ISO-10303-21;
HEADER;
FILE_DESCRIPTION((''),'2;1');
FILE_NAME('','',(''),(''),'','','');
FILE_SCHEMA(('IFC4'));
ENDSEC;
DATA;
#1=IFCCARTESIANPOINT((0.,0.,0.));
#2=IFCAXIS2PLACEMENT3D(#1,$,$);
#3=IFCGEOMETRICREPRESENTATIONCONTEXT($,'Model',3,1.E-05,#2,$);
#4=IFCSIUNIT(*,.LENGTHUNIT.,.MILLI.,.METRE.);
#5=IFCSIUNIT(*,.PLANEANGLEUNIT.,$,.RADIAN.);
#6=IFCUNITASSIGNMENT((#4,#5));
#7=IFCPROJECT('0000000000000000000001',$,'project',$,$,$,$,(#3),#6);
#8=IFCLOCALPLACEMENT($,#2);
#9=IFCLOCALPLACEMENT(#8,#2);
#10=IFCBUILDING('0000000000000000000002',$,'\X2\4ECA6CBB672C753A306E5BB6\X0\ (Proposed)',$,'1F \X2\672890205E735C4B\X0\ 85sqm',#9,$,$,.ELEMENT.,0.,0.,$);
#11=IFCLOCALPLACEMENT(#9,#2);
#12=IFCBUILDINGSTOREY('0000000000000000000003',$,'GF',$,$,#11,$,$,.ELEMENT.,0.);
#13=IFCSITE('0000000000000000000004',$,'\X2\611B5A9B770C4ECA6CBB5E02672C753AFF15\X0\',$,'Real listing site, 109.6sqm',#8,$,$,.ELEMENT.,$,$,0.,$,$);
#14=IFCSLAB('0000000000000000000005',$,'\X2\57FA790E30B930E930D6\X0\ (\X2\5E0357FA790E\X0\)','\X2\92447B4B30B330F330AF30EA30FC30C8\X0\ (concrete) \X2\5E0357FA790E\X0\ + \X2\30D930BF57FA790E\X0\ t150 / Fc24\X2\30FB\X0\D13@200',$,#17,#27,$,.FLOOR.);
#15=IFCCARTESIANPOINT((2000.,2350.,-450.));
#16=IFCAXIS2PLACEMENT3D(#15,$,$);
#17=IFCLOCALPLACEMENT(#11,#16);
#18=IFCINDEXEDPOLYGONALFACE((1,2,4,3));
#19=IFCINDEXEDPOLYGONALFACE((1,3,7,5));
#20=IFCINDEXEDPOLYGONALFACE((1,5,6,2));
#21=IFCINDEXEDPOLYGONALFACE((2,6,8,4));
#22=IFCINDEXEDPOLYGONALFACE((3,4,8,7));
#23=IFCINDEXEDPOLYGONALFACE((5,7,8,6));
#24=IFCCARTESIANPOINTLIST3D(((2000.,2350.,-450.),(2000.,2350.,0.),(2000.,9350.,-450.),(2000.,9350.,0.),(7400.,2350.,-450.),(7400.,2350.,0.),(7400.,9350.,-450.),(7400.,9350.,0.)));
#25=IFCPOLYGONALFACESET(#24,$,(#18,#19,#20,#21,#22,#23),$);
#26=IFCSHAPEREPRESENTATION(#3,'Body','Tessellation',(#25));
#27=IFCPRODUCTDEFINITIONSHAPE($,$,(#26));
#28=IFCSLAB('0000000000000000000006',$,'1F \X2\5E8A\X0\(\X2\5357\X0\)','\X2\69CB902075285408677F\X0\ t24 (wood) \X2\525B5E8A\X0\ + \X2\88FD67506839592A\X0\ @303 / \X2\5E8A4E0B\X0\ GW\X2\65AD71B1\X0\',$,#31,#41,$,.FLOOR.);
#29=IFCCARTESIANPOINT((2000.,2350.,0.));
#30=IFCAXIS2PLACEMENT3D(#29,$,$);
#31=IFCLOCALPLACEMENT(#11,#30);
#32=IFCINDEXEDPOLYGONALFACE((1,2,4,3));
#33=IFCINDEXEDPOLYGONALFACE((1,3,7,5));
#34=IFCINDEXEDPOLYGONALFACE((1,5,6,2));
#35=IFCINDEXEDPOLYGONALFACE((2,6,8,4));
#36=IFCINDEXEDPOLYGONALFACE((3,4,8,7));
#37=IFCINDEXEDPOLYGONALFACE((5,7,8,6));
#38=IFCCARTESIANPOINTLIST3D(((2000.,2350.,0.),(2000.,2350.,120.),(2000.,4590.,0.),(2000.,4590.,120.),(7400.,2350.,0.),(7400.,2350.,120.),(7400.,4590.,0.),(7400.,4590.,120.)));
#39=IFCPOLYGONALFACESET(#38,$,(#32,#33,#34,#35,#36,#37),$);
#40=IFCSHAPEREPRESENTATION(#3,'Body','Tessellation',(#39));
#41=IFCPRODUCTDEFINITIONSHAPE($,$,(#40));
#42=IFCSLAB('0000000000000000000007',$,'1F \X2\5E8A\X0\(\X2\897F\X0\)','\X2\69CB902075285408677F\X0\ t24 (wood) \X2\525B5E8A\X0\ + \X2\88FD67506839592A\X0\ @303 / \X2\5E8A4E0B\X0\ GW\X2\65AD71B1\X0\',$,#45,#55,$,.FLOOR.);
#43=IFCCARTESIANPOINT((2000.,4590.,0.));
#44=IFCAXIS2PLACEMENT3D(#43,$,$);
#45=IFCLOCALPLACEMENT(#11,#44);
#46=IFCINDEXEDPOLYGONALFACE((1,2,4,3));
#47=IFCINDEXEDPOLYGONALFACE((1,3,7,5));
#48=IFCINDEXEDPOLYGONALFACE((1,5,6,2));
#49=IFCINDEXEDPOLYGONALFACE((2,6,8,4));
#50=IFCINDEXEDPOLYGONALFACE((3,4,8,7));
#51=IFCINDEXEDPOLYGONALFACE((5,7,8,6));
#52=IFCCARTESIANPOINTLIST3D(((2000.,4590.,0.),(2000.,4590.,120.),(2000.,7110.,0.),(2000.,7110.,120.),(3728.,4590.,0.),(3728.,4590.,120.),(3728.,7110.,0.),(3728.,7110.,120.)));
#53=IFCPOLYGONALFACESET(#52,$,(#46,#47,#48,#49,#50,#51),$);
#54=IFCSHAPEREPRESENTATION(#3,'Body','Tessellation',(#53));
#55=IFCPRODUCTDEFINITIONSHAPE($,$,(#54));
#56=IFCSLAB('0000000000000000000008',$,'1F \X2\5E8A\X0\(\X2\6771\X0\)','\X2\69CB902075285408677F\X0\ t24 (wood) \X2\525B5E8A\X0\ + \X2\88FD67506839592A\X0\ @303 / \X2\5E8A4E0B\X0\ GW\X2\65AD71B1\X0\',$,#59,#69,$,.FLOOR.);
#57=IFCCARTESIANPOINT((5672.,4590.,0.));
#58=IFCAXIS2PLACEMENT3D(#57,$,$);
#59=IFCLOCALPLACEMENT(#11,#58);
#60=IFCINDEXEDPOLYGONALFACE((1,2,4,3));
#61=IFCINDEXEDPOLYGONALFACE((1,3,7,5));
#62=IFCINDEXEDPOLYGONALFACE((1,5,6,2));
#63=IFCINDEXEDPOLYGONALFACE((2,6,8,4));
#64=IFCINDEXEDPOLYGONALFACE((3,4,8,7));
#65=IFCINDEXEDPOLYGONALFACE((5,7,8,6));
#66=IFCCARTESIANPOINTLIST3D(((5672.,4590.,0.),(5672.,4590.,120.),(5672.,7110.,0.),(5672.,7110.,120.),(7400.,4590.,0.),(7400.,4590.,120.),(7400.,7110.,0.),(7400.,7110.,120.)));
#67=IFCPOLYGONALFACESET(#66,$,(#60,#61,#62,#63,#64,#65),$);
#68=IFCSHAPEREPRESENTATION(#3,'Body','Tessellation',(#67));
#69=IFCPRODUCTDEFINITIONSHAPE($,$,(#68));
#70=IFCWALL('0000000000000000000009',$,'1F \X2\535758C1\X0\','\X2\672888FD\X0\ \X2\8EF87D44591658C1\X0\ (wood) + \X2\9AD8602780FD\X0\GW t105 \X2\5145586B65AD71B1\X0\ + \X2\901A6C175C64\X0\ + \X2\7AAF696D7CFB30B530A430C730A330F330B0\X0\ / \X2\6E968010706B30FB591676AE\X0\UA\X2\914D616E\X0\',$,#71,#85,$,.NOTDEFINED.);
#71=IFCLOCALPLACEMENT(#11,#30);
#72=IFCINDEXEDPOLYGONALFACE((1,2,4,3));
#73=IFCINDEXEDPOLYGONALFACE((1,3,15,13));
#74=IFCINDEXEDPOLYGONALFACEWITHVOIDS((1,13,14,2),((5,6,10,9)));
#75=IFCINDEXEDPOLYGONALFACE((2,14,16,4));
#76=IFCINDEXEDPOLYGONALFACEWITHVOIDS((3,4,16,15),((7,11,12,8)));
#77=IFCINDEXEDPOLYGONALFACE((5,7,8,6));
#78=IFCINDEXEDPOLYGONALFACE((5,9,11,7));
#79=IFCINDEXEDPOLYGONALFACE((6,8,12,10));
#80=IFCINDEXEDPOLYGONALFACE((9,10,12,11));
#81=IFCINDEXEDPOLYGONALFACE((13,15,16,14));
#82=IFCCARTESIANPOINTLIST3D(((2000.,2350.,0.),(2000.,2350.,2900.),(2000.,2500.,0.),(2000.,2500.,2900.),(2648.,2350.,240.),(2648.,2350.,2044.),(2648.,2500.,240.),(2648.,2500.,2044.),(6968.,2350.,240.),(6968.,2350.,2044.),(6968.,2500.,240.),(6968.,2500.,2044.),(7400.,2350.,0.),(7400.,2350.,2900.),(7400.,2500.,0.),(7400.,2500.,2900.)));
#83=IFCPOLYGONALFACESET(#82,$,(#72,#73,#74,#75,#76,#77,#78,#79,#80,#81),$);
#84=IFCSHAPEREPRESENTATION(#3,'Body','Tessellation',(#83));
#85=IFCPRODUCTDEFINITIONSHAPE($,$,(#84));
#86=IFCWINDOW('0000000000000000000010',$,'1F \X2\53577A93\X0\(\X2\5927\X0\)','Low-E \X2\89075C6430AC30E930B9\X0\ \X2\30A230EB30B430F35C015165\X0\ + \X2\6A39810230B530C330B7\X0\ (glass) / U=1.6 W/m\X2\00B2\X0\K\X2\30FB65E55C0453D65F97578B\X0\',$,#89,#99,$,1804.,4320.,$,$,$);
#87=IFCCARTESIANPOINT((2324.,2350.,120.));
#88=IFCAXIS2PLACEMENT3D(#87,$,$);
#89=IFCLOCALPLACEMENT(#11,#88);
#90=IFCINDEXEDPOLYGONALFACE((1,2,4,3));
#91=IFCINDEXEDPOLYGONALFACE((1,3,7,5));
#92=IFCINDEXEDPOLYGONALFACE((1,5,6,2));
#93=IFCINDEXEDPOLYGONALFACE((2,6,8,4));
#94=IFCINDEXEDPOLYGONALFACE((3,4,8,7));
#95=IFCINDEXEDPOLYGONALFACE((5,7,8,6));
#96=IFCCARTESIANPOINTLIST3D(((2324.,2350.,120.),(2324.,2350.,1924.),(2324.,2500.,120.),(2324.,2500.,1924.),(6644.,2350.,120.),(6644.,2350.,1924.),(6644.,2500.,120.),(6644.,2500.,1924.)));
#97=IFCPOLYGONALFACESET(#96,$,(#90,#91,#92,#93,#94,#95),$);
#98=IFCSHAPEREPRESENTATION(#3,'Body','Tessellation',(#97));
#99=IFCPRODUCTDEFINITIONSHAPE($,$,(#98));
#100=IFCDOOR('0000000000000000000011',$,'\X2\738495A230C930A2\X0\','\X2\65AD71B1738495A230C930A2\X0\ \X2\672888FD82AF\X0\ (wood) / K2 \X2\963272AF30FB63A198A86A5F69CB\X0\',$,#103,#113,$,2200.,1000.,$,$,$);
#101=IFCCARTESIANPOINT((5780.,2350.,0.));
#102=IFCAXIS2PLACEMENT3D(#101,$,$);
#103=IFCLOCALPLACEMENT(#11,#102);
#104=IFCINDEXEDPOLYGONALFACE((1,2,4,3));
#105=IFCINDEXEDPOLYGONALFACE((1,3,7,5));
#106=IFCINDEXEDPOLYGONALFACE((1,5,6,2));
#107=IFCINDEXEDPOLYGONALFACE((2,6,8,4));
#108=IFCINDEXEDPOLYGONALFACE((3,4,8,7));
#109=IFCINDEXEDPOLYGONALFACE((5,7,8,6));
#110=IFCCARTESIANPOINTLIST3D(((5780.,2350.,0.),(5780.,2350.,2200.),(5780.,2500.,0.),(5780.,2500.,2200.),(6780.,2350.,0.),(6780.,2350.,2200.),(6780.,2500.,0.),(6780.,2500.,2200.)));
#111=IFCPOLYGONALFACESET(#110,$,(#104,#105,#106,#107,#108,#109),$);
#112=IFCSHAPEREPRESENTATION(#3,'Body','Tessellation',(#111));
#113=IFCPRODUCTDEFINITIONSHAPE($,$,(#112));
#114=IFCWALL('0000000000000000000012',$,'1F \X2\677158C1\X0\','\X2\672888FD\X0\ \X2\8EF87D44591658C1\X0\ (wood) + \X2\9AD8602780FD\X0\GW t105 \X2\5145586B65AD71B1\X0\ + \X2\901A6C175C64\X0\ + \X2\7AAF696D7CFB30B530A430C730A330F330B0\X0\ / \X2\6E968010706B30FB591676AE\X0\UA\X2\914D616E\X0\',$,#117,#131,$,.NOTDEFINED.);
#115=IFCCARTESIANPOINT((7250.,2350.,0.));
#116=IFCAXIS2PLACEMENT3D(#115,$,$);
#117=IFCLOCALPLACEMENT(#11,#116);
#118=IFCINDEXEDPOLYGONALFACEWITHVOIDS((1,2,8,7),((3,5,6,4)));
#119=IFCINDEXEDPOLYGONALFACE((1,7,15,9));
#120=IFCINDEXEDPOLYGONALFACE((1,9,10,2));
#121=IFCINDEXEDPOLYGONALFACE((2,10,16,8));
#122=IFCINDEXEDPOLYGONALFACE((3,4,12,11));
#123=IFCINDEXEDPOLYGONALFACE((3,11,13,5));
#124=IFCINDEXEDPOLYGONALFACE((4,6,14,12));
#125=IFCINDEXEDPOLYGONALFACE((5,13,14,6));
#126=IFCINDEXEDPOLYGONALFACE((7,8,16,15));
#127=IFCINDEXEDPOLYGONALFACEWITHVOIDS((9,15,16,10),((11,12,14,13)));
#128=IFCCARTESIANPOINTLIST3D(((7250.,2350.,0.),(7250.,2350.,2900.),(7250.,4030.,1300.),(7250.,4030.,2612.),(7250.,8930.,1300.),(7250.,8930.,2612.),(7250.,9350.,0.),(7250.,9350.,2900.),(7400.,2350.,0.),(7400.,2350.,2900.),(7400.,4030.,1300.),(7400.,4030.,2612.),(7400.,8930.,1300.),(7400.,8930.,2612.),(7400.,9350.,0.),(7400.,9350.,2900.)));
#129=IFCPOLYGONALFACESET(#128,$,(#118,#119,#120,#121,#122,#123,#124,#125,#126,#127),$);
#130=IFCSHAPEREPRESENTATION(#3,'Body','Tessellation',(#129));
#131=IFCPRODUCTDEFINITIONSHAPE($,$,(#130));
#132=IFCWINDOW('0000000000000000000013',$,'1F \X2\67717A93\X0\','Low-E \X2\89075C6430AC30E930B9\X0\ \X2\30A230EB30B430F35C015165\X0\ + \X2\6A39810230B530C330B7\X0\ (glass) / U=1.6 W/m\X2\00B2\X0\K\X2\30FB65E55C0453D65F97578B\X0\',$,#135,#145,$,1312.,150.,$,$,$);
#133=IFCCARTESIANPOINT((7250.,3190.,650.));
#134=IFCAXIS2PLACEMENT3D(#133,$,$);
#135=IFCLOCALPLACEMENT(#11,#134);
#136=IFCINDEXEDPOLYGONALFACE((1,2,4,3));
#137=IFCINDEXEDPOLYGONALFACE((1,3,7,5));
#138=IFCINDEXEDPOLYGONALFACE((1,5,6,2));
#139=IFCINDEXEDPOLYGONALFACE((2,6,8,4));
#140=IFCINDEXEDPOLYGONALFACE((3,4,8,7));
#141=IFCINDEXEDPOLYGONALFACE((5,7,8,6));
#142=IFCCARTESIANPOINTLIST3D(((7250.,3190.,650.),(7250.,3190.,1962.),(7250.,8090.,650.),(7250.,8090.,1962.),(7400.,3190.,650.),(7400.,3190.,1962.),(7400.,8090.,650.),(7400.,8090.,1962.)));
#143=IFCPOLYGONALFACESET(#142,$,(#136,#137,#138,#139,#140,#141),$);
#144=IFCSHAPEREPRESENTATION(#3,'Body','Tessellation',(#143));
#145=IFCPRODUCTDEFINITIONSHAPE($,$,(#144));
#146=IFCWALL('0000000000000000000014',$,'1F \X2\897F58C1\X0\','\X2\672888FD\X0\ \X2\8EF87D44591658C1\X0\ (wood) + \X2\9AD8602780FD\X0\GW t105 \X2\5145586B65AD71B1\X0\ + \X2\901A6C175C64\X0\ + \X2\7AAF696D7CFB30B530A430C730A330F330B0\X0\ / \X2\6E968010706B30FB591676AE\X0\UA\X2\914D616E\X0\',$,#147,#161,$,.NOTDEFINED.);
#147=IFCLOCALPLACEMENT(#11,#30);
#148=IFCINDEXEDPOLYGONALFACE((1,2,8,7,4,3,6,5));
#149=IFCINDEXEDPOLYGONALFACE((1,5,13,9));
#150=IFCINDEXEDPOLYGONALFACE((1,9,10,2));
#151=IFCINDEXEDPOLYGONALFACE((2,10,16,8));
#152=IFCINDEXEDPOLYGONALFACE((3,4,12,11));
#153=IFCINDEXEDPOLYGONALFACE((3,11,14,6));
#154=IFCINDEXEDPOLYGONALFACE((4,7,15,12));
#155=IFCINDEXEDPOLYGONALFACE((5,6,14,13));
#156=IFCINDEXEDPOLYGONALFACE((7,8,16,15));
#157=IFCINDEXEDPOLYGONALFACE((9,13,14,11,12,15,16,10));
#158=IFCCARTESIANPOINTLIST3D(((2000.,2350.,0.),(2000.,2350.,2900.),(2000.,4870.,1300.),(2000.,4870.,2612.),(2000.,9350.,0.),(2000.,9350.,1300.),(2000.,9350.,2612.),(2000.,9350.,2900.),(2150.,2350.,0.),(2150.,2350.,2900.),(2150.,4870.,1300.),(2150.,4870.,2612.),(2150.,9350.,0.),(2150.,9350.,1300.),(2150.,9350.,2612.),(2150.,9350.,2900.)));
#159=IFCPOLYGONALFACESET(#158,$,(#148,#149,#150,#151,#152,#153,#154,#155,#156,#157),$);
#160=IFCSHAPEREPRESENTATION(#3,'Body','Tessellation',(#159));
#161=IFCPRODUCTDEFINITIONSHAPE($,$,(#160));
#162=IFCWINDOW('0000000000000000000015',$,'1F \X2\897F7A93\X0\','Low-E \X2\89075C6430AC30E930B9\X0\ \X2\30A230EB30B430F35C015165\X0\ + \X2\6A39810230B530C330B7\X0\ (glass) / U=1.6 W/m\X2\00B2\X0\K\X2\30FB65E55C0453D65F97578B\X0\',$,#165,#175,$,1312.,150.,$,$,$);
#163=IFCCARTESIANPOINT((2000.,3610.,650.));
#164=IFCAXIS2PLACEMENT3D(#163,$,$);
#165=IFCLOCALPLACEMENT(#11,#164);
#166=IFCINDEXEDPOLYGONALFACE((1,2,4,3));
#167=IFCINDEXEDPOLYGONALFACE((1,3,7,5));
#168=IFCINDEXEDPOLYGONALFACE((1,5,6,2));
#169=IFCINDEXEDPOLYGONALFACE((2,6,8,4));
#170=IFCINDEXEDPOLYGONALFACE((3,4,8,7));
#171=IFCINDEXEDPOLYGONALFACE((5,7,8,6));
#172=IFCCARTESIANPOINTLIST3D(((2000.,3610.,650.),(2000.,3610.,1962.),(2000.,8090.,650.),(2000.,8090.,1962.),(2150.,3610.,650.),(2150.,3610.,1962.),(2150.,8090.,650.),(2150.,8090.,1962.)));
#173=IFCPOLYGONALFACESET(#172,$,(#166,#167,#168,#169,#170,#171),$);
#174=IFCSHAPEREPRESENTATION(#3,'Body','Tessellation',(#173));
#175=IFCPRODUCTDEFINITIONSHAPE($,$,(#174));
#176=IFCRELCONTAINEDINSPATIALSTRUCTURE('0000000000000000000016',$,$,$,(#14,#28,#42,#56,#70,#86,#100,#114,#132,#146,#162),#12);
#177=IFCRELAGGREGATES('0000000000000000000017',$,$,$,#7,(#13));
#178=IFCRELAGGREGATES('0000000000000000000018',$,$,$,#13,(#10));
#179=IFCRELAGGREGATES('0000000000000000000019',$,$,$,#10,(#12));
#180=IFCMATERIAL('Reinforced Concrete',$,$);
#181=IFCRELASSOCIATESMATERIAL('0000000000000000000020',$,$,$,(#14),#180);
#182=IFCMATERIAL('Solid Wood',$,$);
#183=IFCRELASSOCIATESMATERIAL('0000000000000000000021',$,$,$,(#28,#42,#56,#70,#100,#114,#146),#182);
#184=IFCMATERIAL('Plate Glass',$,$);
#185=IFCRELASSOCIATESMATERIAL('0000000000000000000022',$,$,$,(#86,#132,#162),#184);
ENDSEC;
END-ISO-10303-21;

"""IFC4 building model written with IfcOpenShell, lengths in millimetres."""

from ifc_helpers import new_model, si_unit, frame, frame_2d, origin, place, context, project, spatial, rectangle, extrude, material, element, fill, save


model = new_model("IFC4")

# Units and contexts
model_context = context("Model", 3, precision=1e-05, world=origin())
ifc_project = project(units=[si_unit("LENGTHUNIT", "METRE", prefix="MILLI"), si_unit("PLANEANGLEUNIT", "RADIAN")], contexts=[model_context])

# Site, building, storey
site_placement = place(None, origin())
site = spatial("IfcSite", under=ifc_project, at=site_placement, Name="愛媛県今治市本町５", ObjectType="Real listing site, 109.6sqm", CompositionType="ELEMENT", RefElevation=0.0)
building_placement = place(site_placement, origin())
building = spatial("IfcBuilding", under=site, at=building_placement, Name="今治本町の家 (Proposed)", ObjectType="1F 木造平屋 85sqm", CompositionType="ELEMENT", ElevationOfRefHeight=0.0, ElevationOfTerrain=0.0)
storey_placement = place(building_placement, origin())
storey = spatial("IfcBuildingStorey", under=building, at=storey_placement, Name="GF", CompositionType="ELEMENT", Elevation=0.0)

# Slabs
ifc_material_1 = material(Name="Reinforced Concrete")
slab_1_placement = place(storey_placement, frame((2000.0, 2350.0, -450.0)))
element("IfcSlab", 1, at=slab_1_placement, inside=storey, material=ifc_material_1, Name="基礎スラブ (布基礎)", Description="鉄筋コンクリート (concrete) 布基礎 + ベタ基礎 t150 / Fc24・D13@200", PredefinedType="FLOOR", context=model_context, shape_type="SweptSolid", body=[
    extrude(rectangle(XDim=5400.0, YDim=7000.0, at=frame_2d((2700.0, 3500.0))), frame((2000.0, 2350.0, -450.0)), (0.0, 0.0, 1.0), 450.0),
])
ifc_material_2 = material(Name="Solid Wood")
slab_2_placement = place(storey_placement, frame((2000.0, 2350.0, 0.0)))
element("IfcSlab", 2, at=slab_2_placement, inside=storey, material=ifc_material_2, Name="1F 床(南)", Description="構造用合板 t24 (wood) 剛床 + 製材根太 @303 / 床下 GW断熱", PredefinedType="FLOOR", context=model_context, shape_type="SweptSolid", body=[
    extrude(rectangle(XDim=5400.0, YDim=2240.0, at=frame_2d((2700.0, 1120.0))), frame((2000.0, 2350.0, 0.0)), (0.0, 0.0, 1.0), 120.0),
])
slab_3_placement = place(storey_placement, frame((2000.0, 4590.0, 0.0)))
element("IfcSlab", 3, at=slab_3_placement, inside=storey, material=ifc_material_2, Name="1F 床(西)", Description="構造用合板 t24 (wood) 剛床 + 製材根太 @303 / 床下 GW断熱", PredefinedType="FLOOR", context=model_context, shape_type="SweptSolid", body=[
    extrude(rectangle(XDim=1728.0, YDim=2520.0, at=frame_2d((864.0, 1260.0))), frame((2000.0, 4590.0, 0.0)), (0.0, 0.0, 1.0), 120.0),
])
slab_4_placement = place(storey_placement, frame((5672.0, 4590.0, 0.0)))
element("IfcSlab", 4, at=slab_4_placement, inside=storey, material=ifc_material_2, Name="1F 床(東)", Description="構造用合板 t24 (wood) 剛床 + 製材根太 @303 / 床下 GW断熱", PredefinedType="FLOOR", context=model_context, shape_type="SweptSolid", body=[
    extrude(rectangle(XDim=1728.0, YDim=2520.0, at=frame_2d((864.0, 1260.0))), frame((5672.0, 4590.0, 0.0)), (0.0, 0.0, 1.0), 120.0),
])

# Wall, openings, window, door
wall_1_placement = place(storey_placement, frame((2000.0, 2350.0, 0.0)))
wall_1 = element("IfcWall", 5, at=wall_1_placement, inside=storey, material=ifc_material_2, Name="1F 南壁", Description="木製 軸組外壁 (wood) + 高性能GW t105 充填断熱 + 通気層 + 窯業系サイディング / 準耐火・外皮UA配慮", PredefinedType="NOTDEFINED", context=model_context, shape_type="SweptSolid", body=[
    extrude(rectangle(XDim=5400.0, YDim=150.0, at=frame_2d((2700.0, 75.0))), frame((2000.0, 2350.0, 0.0)), (0.0, 0.0, 1.0), 2900.0),
])
opening_1_placement = place(storey_placement, frame((2324.0, 2350.0, 120.0)))
opening_1 = element("IfcOpeningElement", 6, at=opening_1_placement, cuts=wall_1, PredefinedType="NOTDEFINED", context=model_context, shape_type="SweptSolid", body=[
    extrude(rectangle(XDim=4320.0, YDim=150.0, at=frame_2d((2160.0, 75.0))), frame((2324.0, 2350.0, 120.0)), (0.0, 0.0, 1.0), 1804.0),
])
opening_2_placement = place(storey_placement, frame((5780.0, 2350.0, 0.0)))
opening_2 = element("IfcOpeningElement", 7, at=opening_2_placement, cuts=wall_1, PredefinedType="NOTDEFINED", context=model_context, shape_type="SweptSolid", body=[
    extrude(rectangle(XDim=1000.0, YDim=150.0, at=frame_2d((500.0, 75.0))), frame((5780.0, 2350.0, 0.0)), (0.0, 0.0, 1.0), 2200.0),
])
ifc_material_3 = material(Name="Plate Glass")
window_1_placement = place(storey_placement, frame((2324.0, 2350.0, 120.0)))
window_1 = element("IfcWindow", 8, at=window_1_placement, inside=storey, material=ifc_material_3, Name="1F 南窓(大)", Description="Low-E 複層ガラス アルゴン封入 + 樹脂サッシ (glass) / U=1.6 W/m²K・日射取得型", OverallHeight=1804.0, OverallWidth=4320.0, context=model_context, shape_type="SweptSolid", body=[
    extrude(rectangle(XDim=4320.0, YDim=150.0, at=frame_2d((2160.0, 75.0))), frame((2324.0, 2350.0, 120.0)), (0.0, 0.0, 1.0), 1804.0),
])
fill(opening_1, window_1)
door_placement = place(storey_placement, frame((5780.0, 2350.0, 0.0)))
door = element("IfcDoor", 9, at=door_placement, inside=storey, material=ifc_material_2, Name="玄関ドア", Description="断熱玄関ドア 木製芯 (wood) / K2 防犯・採風機構", OverallHeight=2200.0, OverallWidth=1000.0, context=model_context, shape_type="SweptSolid", body=[
    extrude(rectangle(XDim=1000.0, YDim=150.0, at=frame_2d((500.0, 75.0))), frame((5780.0, 2350.0, 0.0)), (0.0, 0.0, 1.0), 2200.0),
])
fill(opening_2, door)

# Walls, openings, windows
wall_2_placement = place(storey_placement, frame((7250.0, 2350.0, 0.0)))
wall_2 = element("IfcWall", 10, at=wall_2_placement, inside=storey, material=ifc_material_2, Name="1F 東壁", Description="木製 軸組外壁 (wood) + 高性能GW t105 充填断熱 + 通気層 + 窯業系サイディング / 準耐火・外皮UA配慮", PredefinedType="NOTDEFINED", context=model_context, shape_type="SweptSolid", body=[
    extrude(rectangle(XDim=150.0, YDim=7000.0, at=frame_2d((75.0, 3500.0))), frame((7250.0, 2350.0, 0.0)), (0.0, 0.0, 1.0), 2900.0),
])
opening_3_placement = place(storey_placement, frame((7250.0, 3190.0, 650.0)))
opening_3 = element("IfcOpeningElement", 11, at=opening_3_placement, cuts=wall_2, PredefinedType="NOTDEFINED", context=model_context, shape_type="SweptSolid", body=[
    extrude(rectangle(XDim=150.0, YDim=4900.0, at=frame_2d((75.0, 2450.0))), frame((7250.0, 3190.0, 650.0)), (0.0, 0.0, 1.0), 1312.0),
])
window_2_placement = place(storey_placement, frame((7250.0, 3190.0, 650.0)))
window_2 = element("IfcWindow", 12, at=window_2_placement, inside=storey, material=ifc_material_3, Name="1F 東窓", Description="Low-E 複層ガラス アルゴン封入 + 樹脂サッシ (glass) / U=1.6 W/m²K・日射取得型", OverallHeight=1312.0, OverallWidth=150.0, context=model_context, shape_type="SweptSolid", body=[
    extrude(rectangle(XDim=150.0, YDim=4900.0, at=frame_2d((75.0, 2450.0))), frame((7250.0, 3190.0, 650.0)), (0.0, 0.0, 1.0), 1312.0),
])
fill(opening_3, window_2)
wall_3_placement = place(storey_placement, frame((2000.0, 2350.0, 0.0)))
wall_3 = element("IfcWall", 13, at=wall_3_placement, inside=storey, material=ifc_material_2, Name="1F 西壁", Description="木製 軸組外壁 (wood) + 高性能GW t105 充填断熱 + 通気層 + 窯業系サイディング / 準耐火・外皮UA配慮", PredefinedType="NOTDEFINED", context=model_context, shape_type="SweptSolid", body=[
    extrude(rectangle(XDim=150.0, YDim=7000.0, at=frame_2d((75.0, 3500.0))), frame((2000.0, 2350.0, 0.0)), (0.0, 0.0, 1.0), 2900.0),
])
opening_4_placement = place(storey_placement, frame((2000.0, 3610.0, 650.0)))
opening_4 = element("IfcOpeningElement", 14, at=opening_4_placement, cuts=wall_3, PredefinedType="NOTDEFINED", context=model_context, shape_type="SweptSolid", body=[
    extrude(rectangle(XDim=150.0, YDim=4480.0, at=frame_2d((75.0, 2240.0))), frame((2000.0, 3610.0, 650.0)), (0.0, 0.0, 1.0), 1312.0),
])
window_3_placement = place(storey_placement, frame((2000.0, 3610.0, 650.0)))
window_3 = element("IfcWindow", 15, at=window_3_placement, inside=storey, material=ifc_material_3, Name="1F 西窓", Description="Low-E 複層ガラス アルゴン封入 + 樹脂サッシ (glass) / U=1.6 W/m²K・日射取得型", OverallHeight=1312.0, OverallWidth=150.0, context=model_context, shape_type="SweptSolid", body=[
    extrude(rectangle(XDim=150.0, YDim=4480.0, at=frame_2d((75.0, 2240.0))), frame((2000.0, 3610.0, 650.0)), (0.0, 0.0, 1.0), 1312.0),
])
fill(opening_4, window_3)

save(model, "model.ifc")
